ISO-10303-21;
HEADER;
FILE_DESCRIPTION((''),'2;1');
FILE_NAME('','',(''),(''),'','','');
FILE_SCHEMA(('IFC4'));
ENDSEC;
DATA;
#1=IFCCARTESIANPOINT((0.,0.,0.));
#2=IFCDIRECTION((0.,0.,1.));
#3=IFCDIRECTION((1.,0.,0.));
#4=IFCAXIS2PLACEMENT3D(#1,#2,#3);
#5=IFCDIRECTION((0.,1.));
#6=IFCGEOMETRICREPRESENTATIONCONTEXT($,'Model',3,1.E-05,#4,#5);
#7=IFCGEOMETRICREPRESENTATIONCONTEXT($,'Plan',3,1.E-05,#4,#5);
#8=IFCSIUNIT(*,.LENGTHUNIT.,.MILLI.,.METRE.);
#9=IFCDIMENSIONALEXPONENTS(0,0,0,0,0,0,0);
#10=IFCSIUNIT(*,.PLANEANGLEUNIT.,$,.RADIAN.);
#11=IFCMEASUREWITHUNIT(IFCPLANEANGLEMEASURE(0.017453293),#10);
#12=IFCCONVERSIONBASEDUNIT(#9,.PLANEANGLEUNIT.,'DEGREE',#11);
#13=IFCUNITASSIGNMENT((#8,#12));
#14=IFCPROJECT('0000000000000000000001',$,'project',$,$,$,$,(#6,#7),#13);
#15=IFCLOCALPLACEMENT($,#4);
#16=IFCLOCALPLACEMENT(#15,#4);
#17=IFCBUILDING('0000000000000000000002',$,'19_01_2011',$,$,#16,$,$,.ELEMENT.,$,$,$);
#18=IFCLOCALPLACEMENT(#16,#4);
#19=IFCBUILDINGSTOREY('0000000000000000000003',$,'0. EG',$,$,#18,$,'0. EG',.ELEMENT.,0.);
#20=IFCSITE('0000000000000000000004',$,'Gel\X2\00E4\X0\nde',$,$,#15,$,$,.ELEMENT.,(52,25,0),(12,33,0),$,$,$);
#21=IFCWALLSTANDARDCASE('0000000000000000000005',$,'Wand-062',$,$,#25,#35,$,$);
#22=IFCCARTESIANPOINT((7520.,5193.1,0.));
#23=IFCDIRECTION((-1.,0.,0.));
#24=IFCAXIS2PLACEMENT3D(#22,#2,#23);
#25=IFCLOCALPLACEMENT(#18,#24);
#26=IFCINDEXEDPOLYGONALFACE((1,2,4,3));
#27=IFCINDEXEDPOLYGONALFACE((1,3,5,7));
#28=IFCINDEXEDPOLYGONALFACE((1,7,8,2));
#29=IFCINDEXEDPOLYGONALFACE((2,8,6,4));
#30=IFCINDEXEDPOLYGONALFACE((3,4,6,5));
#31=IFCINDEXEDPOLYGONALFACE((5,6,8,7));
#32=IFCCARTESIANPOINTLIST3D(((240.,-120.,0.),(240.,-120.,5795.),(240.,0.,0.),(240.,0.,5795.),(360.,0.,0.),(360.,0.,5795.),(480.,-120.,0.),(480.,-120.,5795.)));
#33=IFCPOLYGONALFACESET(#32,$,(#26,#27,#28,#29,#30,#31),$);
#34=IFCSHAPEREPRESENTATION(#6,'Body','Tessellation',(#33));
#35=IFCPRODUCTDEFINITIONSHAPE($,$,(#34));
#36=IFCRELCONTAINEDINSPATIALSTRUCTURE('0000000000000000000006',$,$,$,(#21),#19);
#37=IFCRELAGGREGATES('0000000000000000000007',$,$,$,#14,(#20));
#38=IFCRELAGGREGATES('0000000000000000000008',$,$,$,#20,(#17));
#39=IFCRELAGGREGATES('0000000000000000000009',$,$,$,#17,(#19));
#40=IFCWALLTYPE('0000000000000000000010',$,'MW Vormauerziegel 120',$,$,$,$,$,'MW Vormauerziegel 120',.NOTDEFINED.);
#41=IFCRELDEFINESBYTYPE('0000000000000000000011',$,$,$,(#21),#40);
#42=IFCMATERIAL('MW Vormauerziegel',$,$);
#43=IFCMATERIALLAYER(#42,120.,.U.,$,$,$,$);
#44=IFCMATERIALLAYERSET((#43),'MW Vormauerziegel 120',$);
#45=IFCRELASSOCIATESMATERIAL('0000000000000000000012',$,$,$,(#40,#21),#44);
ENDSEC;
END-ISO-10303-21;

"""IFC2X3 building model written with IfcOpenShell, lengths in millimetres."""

from ifc_helpers import new_model, entity, si_unit, converted_unit, direction, frame, origin_with_axes, place, context, project, spatial, polyline, outline, extrude, material, layer, layer_set, layer_usage, type_object, element, save


model = new_model("IFC2X3")

# Units and contexts
model_context = context("Model", 3, precision=1e-05, world=origin_with_axes(), true_north=direction((0.0, 1.0)))
plan_context = context("Plan", 3, precision=1e-05, world=origin_with_axes(), true_north=direction((0.0, 1.0)))
ifc_project = project(units=[si_unit("LENGTHUNIT", "METRE", prefix="MILLI"), converted_unit("PLANEANGLEUNIT", "DEGREE", entity("IfcPlaneAngleMeasure", 0.017453293), si_unit("PLANEANGLEUNIT", "RADIAN"), dimensions=[0, 0, 0, 0, 0, 0, 0])], contexts=[model_context, plan_context])

# Site, building, storey
site_placement = place(None, origin_with_axes())
site = spatial("IfcSite", under=ifc_project, at=site_placement, Name="Gelände", CompositionType="ELEMENT", RefLatitude=(52, 25, 0), RefLongitude=(12, 33, 0))
building_placement = place(site_placement, origin_with_axes())
building = spatial("IfcBuilding", under=site, at=building_placement, Name="19_01_2011", CompositionType="ELEMENT")
storey_placement = place(building_placement, origin_with_axes())
storey = spatial("IfcBuildingStorey", under=building, at=storey_placement, Name="0. EG", LongName="0. EG", CompositionType="ELEMENT", Elevation=0.0)

# Shared definitions
ifc_material_1 = material(Name="MW Vormauerziegel")

# Wall
ifc_layer_1 = layer(ifc_material_1, 120.0, ventilated="UNKNOWN")
ifc_layer_set_1 = layer_set([ifc_layer_1], Name="MW Vormauerziegel 120")
ifc_layer_usage_1 = layer_usage(ifc_layer_set_1, "AXIS2", "NEGATIVE", 0.0)
wall_type_1 = type_object("IfcWallType", Name="MW Vormauerziegel 120", ElementType="MW Vormauerziegel 120", PredefinedType="NOTDEFINED", material=ifc_layer_set_1)
wall_1_placement = place(storey_placement, frame((7520.0, 5193.1, 0.0), z_axis=(0.0, 0.0, 1.0), x_axis=(-1.0, 0.0, 0.0)))
element("IfcWallStandardCase", 1, at=wall_1_placement, inside=storey, type_object=wall_type_1, material=ifc_layer_usage_1, Name="Wand-062", context=model_context, shape_type="SweptSolid", body=[
    extrude(outline(polyline([(240.0, -120.0), (480.0, -120.0), (360.0, 0.0), (240.0, 0.0), (240.0, -120.0)])), origin_with_axes(), (0.0, 0.0, 1.0), 5795.0),
])

save(model, "model.ifc")
